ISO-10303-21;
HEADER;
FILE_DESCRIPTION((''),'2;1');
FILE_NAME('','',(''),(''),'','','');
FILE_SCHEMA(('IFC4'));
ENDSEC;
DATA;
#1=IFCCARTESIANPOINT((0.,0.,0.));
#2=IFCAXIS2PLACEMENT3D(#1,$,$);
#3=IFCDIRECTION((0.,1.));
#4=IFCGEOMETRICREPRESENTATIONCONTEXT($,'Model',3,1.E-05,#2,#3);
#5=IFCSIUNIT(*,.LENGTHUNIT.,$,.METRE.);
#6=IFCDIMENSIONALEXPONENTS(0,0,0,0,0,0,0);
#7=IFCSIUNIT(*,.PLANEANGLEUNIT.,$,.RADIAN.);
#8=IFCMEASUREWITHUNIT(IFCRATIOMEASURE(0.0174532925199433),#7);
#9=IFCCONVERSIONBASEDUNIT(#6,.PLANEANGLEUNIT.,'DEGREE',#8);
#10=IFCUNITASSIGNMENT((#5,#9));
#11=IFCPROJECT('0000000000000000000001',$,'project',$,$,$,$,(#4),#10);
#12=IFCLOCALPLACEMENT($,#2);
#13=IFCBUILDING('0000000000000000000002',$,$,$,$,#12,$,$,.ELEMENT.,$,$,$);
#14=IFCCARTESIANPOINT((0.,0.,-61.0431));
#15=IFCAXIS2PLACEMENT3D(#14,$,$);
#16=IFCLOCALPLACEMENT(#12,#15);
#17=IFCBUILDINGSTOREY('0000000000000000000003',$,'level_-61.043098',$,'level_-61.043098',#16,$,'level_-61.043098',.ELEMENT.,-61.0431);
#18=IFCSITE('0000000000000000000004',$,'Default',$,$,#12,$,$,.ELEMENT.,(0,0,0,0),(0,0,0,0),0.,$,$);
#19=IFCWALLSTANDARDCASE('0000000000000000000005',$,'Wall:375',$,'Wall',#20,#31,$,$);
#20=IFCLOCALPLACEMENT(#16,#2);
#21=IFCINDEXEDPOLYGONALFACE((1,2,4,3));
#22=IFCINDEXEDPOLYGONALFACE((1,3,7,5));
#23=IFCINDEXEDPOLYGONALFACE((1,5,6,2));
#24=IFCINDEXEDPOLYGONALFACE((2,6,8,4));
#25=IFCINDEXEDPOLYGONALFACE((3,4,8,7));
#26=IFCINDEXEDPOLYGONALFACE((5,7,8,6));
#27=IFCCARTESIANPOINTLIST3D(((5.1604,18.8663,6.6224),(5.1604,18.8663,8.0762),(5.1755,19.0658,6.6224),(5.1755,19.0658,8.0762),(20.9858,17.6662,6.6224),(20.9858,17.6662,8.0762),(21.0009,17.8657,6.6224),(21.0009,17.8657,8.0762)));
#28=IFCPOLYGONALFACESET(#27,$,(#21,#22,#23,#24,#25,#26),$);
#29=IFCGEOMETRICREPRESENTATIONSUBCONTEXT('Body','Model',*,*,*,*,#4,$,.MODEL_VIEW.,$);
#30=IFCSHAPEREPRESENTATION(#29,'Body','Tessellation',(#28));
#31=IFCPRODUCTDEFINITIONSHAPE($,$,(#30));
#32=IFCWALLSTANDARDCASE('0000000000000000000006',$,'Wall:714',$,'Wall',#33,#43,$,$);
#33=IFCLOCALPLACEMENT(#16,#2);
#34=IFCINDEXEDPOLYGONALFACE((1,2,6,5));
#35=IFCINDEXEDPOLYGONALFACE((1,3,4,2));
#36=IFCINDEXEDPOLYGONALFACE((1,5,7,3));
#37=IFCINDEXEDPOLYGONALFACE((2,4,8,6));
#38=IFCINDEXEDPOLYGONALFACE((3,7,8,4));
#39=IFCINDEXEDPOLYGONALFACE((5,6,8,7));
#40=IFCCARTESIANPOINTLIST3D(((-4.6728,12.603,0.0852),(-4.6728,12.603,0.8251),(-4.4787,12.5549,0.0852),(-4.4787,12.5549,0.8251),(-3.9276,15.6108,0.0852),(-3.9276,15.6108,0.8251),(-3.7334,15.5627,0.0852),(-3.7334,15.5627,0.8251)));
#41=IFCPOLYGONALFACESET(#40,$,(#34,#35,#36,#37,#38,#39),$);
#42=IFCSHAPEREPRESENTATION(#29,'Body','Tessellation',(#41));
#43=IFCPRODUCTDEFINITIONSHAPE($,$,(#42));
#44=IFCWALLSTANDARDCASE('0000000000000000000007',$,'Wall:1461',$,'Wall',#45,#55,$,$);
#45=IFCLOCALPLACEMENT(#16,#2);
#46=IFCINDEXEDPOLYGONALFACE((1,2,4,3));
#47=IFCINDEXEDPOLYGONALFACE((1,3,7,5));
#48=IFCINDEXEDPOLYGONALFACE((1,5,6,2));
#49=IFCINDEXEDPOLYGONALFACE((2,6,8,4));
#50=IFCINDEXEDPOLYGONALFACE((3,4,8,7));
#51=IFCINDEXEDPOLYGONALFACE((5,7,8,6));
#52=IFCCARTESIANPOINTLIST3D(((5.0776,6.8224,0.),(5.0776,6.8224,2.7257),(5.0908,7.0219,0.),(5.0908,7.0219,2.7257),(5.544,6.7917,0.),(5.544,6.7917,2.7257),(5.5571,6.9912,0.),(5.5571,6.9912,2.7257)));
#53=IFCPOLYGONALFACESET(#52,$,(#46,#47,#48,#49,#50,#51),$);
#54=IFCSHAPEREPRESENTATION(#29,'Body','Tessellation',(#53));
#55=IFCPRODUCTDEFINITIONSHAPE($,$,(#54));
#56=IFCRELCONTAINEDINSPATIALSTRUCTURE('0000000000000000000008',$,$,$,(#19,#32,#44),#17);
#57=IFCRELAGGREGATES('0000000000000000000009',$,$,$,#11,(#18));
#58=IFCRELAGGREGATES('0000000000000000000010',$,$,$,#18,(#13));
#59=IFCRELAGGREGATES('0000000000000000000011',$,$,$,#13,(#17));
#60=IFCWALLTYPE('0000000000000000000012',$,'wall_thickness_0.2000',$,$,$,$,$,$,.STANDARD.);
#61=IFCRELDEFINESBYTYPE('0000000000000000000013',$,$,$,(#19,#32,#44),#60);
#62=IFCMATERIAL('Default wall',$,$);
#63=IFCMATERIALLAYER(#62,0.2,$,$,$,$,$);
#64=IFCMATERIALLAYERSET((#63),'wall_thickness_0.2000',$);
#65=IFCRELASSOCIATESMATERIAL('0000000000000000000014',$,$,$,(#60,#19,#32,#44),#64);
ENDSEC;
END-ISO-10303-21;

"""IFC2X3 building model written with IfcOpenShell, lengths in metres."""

from ifc_helpers import new_model, entity, si_unit, converted_unit, direction, frame, origin, place, context, subcontext, project, spatial, polyline, outline, extrude, material, layer, layer_set, layer_usage, type_object, element, save


model = new_model("IFC2X3")

# Units and contexts
model_context = context("Model", 3, precision=1e-05, world=origin(), true_north=direction((0.0, 1.0)))
body_context = subcontext(model_context, "Body", "Model", "MODEL_VIEW")
ifc_project = project(units=[si_unit("LENGTHUNIT", "METRE"), converted_unit("PLANEANGLEUNIT", "DEGREE", entity("IfcRatioMeasure", 0.0174532925199433), si_unit("PLANEANGLEUNIT", "RADIAN"), dimensions=[0, 0, 0, 0, 0, 0, 0])], contexts=[model_context])

# Site, building, storey
placement_1 = place(None, origin())
site = spatial("IfcSite", under=ifc_project, at=placement_1, Name="Default", CompositionType="ELEMENT", RefLatitude=(0, 0, 0, 0), RefLongitude=(0, 0, 0, 0), RefElevation=0.0)
building = spatial("IfcBuilding", under=site, at=placement_1, CompositionType="ELEMENT")
storey_placement = place(placement_1, frame((0.0, 0.0, -61.0431)))
storey = spatial("IfcBuildingStorey", under=building, at=storey_placement, Name="level_-61.043098", ObjectType="level_-61.043098", LongName="level_-61.043098", CompositionType="ELEMENT", Elevation=-61.0431)

# Walls
ifc_material_1 = material(Name="Default wall")
ifc_layer = layer(ifc_material_1, 0.2)
ifc_layer_set = layer_set([ifc_layer], Name="wall_thickness_0.2000")
ifc_layer_usage = layer_usage(ifc_layer_set, "AXIS2", "POSITIVE", -0.1)
wall_type = type_object("IfcWallType", Name="wall_thickness_0.2000", PredefinedType="STANDARD", material=ifc_layer_set)
placement_2 = place(placement_1, frame((0.0, 0.0, -54.4207)))
wall_1_placement = place(placement_2, frame((5.168, 18.9661, 0.0), z_axis=(0.0, 0.0, 1.0), x_axis=(0.997137, -0.075617, 0.0)))
element("IfcWallStandardCase", 1, at=wall_1_placement, inside=storey, type_object=wall_type, material=ifc_layer_usage, Name="Wall:375", ObjectType="Wall", context=body_context, shape_type="SweptSolid", body=[
    extrude(outline(polyline([(15.8708, -0.1), (15.8708, 0.1), (0.0, 0.1), (0.0, -0.1), (15.8708, -0.1)])), origin(), (0.0, 0.0, 1.0), 1.4538),
])
placement_3 = place(placement_1, frame((0.0, 0.0, -60.9579)))
wall_2_placement = place(placement_3, frame((-4.5758, 12.5789, 0.0), z_axis=(0.0, 0.0, 1.0), x_axis=(0.2405, 0.970649, 0.0)))
element("IfcWallStandardCase", 2, at=wall_2_placement, inside=storey, type_object=wall_type, material=ifc_layer_usage, Name="Wall:714", ObjectType="Wall", context=body_context, shape_type="SweptSolid", body=[
    extrude(outline(polyline([(3.0988, -0.1), (3.0988, 0.1), (0.0, 0.1), (0.0, -0.1), (3.0988, -0.1)])), origin(), (0.0, 0.0, 1.0), 0.7399),
])
wall_3_placement = place(storey_placement, frame((5.5505, 6.8915, 0.0), z_axis=(0.0, 0.0, 1.0), x_axis=(-0.997842, 0.065663, 0.0)))
element("IfcWallStandardCase", 3, at=wall_3_placement, inside=storey, type_object=wall_type, material=ifc_layer_usage, Name="Wall:1461", ObjectType="Wall", context=body_context, shape_type="SweptSolid", body=[
    extrude(outline(polyline([(0.4673, -0.1), (0.4673, 0.1), (0.0, 0.1), (0.0, -0.1), (0.4673, -0.1)])), origin(), (0.0, 0.0, 1.0), 2.7257),
])

save(model, "model.ifc")
